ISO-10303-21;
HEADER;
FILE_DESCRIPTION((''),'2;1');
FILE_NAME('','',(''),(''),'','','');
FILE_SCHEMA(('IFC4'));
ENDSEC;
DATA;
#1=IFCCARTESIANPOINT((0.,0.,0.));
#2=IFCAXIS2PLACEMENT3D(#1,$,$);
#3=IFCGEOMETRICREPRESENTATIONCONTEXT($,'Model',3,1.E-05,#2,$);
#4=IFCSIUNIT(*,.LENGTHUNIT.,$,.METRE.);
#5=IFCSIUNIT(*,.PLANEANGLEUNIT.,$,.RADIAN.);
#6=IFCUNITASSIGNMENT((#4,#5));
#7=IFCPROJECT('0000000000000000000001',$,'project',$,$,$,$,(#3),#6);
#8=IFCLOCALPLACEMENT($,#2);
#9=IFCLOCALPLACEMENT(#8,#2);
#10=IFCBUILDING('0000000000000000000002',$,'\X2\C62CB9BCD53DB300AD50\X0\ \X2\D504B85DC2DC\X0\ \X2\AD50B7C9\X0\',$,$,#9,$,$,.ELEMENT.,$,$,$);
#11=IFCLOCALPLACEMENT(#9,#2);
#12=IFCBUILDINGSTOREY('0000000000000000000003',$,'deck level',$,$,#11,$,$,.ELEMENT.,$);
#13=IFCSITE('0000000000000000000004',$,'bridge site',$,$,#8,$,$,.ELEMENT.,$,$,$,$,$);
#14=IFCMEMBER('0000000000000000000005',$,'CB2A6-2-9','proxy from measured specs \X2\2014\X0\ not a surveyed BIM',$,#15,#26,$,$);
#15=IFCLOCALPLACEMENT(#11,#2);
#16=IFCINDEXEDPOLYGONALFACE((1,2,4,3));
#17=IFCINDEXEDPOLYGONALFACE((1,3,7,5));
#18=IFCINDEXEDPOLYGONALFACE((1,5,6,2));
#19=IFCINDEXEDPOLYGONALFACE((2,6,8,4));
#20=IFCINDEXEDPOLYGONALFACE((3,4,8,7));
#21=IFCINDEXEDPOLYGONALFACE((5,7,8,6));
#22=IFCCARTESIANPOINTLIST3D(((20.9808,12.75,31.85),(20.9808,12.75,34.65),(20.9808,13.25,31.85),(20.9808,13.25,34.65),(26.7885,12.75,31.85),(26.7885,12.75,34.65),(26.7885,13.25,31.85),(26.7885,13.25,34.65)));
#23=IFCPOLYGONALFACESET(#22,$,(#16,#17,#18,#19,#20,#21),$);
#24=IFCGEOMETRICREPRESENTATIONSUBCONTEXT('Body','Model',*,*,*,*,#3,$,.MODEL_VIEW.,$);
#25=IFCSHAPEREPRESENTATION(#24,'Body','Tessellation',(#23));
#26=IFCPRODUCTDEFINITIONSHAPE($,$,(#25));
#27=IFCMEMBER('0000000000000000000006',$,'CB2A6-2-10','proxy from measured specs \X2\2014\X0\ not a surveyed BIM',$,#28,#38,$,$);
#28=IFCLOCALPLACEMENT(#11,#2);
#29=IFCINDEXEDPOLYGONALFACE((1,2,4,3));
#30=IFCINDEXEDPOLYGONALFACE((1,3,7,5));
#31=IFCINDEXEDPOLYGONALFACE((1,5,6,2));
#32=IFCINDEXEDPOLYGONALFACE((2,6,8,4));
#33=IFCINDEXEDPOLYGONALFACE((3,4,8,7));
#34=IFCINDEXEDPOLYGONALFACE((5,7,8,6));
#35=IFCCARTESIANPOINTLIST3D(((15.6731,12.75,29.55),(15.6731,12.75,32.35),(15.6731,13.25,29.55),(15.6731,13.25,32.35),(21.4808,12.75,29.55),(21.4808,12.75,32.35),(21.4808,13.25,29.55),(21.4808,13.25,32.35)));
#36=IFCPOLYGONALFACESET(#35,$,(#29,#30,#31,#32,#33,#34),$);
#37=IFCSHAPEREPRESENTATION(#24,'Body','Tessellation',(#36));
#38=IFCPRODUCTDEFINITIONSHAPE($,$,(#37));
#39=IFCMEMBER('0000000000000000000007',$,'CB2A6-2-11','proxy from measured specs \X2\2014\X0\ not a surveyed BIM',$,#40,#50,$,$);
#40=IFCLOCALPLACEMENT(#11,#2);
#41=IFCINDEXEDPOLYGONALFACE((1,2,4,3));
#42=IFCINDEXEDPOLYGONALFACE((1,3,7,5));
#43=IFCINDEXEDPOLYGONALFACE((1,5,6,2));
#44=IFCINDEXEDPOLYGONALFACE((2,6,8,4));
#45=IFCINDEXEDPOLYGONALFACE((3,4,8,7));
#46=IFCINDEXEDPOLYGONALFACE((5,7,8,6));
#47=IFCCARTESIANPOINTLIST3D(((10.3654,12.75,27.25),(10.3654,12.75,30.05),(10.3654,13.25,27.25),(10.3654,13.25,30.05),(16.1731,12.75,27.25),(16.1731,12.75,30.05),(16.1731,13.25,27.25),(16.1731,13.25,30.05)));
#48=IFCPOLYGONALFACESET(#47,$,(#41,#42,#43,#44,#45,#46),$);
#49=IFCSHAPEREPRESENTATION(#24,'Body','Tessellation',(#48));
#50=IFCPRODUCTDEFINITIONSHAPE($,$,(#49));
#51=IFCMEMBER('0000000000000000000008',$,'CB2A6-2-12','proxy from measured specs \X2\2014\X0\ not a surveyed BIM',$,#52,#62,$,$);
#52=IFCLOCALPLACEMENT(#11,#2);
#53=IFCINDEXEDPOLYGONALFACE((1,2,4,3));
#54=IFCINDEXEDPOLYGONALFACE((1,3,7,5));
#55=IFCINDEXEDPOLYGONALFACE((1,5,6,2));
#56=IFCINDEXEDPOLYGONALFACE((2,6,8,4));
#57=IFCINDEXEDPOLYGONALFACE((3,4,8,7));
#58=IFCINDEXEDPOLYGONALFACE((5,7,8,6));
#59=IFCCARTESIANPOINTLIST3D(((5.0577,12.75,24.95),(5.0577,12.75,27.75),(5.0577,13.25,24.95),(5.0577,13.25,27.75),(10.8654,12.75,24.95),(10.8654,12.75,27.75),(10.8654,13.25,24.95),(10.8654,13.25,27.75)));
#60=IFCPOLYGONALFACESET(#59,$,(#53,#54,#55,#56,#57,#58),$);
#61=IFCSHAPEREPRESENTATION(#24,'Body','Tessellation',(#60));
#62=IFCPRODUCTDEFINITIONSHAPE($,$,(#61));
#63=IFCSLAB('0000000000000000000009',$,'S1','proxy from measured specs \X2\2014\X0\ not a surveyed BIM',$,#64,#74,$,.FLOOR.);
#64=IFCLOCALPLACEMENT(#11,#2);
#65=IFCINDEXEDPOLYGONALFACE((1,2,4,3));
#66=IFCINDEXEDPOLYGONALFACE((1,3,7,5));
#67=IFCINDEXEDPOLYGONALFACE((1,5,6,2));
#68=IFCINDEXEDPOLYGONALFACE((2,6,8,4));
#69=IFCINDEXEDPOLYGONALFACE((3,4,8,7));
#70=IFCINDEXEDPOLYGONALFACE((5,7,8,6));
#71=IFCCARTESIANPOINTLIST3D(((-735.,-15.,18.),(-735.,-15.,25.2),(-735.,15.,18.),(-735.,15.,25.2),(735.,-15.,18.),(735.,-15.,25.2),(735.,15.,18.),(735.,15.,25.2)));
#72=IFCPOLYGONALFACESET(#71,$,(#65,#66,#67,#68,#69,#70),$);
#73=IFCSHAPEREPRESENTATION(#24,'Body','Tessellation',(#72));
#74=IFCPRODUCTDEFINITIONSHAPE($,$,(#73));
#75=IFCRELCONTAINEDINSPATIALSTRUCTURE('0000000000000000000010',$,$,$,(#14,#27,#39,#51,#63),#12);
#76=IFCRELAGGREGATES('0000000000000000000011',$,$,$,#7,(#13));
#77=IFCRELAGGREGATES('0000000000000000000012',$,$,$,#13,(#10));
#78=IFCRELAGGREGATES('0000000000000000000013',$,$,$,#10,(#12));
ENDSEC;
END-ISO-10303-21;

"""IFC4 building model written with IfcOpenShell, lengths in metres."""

from ifc_helpers import new_model, si_unit, frame, origin, origin_2d, place, context, subcontext, project, spatial, rectangle, extrude, element, save


model = new_model("IFC4")

# Units and contexts
model_context = context("Model", 3, precision=1e-05, world=origin())
body_context = subcontext(model_context, "Body", "Model", "MODEL_VIEW")
ifc_project = project(units=[si_unit("LENGTHUNIT", "METRE"), si_unit("PLANEANGLEUNIT", "RADIAN")], contexts=[model_context])

# Site, building, storey
site_placement = place(None, origin())
site = spatial("IfcSite", under=ifc_project, at=site_placement, Name="bridge site", CompositionType="ELEMENT")
building_placement = place(site_placement, origin())
building = spatial("IfcBuilding", under=site, at=building_placement, Name="올림픽대교 프록시 교량", CompositionType="ELEMENT")
storey_placement = place(building_placement, origin())
storey = spatial("IfcBuildingStorey", under=building, at=storey_placement, Name="deck level", CompositionType="ELEMENT")

# Members
member_1_placement = place(storey_placement, frame((23.8846, 13.0, 31.85)))
element("IfcMember", 1, at=member_1_placement, inside=storey, Name="CB2A6-2-9", Description="proxy from measured specs — not a surveyed BIM", context=body_context, shape_type="SweptSolid", body=[
    extrude(rectangle(XDim=5.8077, YDim=0.5, at=origin_2d()), origin(), (0.0, 0.0, 1.0), 2.8),
])
member_2_placement = place(storey_placement, frame((18.5769, 13.0, 29.55)))
element("IfcMember", 2, at=member_2_placement, inside=storey, Name="CB2A6-2-10", Description="proxy from measured specs — not a surveyed BIM", context=body_context, shape_type="SweptSolid", body=[
    extrude(rectangle(XDim=5.8077, YDim=0.5, at=origin_2d()), origin(), (0.0, 0.0, 1.0), 2.8),
])
member_3_placement = place(storey_placement, frame((13.2692, 13.0, 27.25)))
element("IfcMember", 3, at=member_3_placement, inside=storey, Name="CB2A6-2-11", Description="proxy from measured specs — not a surveyed BIM", context=body_context, shape_type="SweptSolid", body=[
    extrude(rectangle(XDim=5.8077, YDim=0.5, at=origin_2d()), origin(), (0.0, 0.0, 1.0), 2.8),
])
member_4_placement = place(storey_placement, frame((7.9615, 13.0, 24.95)))
element("IfcMember", 4, at=member_4_placement, inside=storey, Name="CB2A6-2-12", Description="proxy from measured specs — not a surveyed BIM", context=body_context, shape_type="SweptSolid", body=[
    extrude(rectangle(XDim=5.8077, YDim=0.5, at=origin_2d()), origin(), (0.0, 0.0, 1.0), 2.8),
])

# Slab
slab_placement = place(storey_placement, frame((0.0, 0.0, 18.0)))
element("IfcSlab", 5, at=slab_placement, inside=storey, Name="S1", Description="proxy from measured specs — not a surveyed BIM", PredefinedType="FLOOR", context=body_context, shape_type="SweptSolid", body=[
    extrude(rectangle(XDim=1470.0, YDim=30.0, at=origin_2d()), origin(), (0.0, 0.0, 1.0), 7.2),
])

save(model, "model.ifc")
